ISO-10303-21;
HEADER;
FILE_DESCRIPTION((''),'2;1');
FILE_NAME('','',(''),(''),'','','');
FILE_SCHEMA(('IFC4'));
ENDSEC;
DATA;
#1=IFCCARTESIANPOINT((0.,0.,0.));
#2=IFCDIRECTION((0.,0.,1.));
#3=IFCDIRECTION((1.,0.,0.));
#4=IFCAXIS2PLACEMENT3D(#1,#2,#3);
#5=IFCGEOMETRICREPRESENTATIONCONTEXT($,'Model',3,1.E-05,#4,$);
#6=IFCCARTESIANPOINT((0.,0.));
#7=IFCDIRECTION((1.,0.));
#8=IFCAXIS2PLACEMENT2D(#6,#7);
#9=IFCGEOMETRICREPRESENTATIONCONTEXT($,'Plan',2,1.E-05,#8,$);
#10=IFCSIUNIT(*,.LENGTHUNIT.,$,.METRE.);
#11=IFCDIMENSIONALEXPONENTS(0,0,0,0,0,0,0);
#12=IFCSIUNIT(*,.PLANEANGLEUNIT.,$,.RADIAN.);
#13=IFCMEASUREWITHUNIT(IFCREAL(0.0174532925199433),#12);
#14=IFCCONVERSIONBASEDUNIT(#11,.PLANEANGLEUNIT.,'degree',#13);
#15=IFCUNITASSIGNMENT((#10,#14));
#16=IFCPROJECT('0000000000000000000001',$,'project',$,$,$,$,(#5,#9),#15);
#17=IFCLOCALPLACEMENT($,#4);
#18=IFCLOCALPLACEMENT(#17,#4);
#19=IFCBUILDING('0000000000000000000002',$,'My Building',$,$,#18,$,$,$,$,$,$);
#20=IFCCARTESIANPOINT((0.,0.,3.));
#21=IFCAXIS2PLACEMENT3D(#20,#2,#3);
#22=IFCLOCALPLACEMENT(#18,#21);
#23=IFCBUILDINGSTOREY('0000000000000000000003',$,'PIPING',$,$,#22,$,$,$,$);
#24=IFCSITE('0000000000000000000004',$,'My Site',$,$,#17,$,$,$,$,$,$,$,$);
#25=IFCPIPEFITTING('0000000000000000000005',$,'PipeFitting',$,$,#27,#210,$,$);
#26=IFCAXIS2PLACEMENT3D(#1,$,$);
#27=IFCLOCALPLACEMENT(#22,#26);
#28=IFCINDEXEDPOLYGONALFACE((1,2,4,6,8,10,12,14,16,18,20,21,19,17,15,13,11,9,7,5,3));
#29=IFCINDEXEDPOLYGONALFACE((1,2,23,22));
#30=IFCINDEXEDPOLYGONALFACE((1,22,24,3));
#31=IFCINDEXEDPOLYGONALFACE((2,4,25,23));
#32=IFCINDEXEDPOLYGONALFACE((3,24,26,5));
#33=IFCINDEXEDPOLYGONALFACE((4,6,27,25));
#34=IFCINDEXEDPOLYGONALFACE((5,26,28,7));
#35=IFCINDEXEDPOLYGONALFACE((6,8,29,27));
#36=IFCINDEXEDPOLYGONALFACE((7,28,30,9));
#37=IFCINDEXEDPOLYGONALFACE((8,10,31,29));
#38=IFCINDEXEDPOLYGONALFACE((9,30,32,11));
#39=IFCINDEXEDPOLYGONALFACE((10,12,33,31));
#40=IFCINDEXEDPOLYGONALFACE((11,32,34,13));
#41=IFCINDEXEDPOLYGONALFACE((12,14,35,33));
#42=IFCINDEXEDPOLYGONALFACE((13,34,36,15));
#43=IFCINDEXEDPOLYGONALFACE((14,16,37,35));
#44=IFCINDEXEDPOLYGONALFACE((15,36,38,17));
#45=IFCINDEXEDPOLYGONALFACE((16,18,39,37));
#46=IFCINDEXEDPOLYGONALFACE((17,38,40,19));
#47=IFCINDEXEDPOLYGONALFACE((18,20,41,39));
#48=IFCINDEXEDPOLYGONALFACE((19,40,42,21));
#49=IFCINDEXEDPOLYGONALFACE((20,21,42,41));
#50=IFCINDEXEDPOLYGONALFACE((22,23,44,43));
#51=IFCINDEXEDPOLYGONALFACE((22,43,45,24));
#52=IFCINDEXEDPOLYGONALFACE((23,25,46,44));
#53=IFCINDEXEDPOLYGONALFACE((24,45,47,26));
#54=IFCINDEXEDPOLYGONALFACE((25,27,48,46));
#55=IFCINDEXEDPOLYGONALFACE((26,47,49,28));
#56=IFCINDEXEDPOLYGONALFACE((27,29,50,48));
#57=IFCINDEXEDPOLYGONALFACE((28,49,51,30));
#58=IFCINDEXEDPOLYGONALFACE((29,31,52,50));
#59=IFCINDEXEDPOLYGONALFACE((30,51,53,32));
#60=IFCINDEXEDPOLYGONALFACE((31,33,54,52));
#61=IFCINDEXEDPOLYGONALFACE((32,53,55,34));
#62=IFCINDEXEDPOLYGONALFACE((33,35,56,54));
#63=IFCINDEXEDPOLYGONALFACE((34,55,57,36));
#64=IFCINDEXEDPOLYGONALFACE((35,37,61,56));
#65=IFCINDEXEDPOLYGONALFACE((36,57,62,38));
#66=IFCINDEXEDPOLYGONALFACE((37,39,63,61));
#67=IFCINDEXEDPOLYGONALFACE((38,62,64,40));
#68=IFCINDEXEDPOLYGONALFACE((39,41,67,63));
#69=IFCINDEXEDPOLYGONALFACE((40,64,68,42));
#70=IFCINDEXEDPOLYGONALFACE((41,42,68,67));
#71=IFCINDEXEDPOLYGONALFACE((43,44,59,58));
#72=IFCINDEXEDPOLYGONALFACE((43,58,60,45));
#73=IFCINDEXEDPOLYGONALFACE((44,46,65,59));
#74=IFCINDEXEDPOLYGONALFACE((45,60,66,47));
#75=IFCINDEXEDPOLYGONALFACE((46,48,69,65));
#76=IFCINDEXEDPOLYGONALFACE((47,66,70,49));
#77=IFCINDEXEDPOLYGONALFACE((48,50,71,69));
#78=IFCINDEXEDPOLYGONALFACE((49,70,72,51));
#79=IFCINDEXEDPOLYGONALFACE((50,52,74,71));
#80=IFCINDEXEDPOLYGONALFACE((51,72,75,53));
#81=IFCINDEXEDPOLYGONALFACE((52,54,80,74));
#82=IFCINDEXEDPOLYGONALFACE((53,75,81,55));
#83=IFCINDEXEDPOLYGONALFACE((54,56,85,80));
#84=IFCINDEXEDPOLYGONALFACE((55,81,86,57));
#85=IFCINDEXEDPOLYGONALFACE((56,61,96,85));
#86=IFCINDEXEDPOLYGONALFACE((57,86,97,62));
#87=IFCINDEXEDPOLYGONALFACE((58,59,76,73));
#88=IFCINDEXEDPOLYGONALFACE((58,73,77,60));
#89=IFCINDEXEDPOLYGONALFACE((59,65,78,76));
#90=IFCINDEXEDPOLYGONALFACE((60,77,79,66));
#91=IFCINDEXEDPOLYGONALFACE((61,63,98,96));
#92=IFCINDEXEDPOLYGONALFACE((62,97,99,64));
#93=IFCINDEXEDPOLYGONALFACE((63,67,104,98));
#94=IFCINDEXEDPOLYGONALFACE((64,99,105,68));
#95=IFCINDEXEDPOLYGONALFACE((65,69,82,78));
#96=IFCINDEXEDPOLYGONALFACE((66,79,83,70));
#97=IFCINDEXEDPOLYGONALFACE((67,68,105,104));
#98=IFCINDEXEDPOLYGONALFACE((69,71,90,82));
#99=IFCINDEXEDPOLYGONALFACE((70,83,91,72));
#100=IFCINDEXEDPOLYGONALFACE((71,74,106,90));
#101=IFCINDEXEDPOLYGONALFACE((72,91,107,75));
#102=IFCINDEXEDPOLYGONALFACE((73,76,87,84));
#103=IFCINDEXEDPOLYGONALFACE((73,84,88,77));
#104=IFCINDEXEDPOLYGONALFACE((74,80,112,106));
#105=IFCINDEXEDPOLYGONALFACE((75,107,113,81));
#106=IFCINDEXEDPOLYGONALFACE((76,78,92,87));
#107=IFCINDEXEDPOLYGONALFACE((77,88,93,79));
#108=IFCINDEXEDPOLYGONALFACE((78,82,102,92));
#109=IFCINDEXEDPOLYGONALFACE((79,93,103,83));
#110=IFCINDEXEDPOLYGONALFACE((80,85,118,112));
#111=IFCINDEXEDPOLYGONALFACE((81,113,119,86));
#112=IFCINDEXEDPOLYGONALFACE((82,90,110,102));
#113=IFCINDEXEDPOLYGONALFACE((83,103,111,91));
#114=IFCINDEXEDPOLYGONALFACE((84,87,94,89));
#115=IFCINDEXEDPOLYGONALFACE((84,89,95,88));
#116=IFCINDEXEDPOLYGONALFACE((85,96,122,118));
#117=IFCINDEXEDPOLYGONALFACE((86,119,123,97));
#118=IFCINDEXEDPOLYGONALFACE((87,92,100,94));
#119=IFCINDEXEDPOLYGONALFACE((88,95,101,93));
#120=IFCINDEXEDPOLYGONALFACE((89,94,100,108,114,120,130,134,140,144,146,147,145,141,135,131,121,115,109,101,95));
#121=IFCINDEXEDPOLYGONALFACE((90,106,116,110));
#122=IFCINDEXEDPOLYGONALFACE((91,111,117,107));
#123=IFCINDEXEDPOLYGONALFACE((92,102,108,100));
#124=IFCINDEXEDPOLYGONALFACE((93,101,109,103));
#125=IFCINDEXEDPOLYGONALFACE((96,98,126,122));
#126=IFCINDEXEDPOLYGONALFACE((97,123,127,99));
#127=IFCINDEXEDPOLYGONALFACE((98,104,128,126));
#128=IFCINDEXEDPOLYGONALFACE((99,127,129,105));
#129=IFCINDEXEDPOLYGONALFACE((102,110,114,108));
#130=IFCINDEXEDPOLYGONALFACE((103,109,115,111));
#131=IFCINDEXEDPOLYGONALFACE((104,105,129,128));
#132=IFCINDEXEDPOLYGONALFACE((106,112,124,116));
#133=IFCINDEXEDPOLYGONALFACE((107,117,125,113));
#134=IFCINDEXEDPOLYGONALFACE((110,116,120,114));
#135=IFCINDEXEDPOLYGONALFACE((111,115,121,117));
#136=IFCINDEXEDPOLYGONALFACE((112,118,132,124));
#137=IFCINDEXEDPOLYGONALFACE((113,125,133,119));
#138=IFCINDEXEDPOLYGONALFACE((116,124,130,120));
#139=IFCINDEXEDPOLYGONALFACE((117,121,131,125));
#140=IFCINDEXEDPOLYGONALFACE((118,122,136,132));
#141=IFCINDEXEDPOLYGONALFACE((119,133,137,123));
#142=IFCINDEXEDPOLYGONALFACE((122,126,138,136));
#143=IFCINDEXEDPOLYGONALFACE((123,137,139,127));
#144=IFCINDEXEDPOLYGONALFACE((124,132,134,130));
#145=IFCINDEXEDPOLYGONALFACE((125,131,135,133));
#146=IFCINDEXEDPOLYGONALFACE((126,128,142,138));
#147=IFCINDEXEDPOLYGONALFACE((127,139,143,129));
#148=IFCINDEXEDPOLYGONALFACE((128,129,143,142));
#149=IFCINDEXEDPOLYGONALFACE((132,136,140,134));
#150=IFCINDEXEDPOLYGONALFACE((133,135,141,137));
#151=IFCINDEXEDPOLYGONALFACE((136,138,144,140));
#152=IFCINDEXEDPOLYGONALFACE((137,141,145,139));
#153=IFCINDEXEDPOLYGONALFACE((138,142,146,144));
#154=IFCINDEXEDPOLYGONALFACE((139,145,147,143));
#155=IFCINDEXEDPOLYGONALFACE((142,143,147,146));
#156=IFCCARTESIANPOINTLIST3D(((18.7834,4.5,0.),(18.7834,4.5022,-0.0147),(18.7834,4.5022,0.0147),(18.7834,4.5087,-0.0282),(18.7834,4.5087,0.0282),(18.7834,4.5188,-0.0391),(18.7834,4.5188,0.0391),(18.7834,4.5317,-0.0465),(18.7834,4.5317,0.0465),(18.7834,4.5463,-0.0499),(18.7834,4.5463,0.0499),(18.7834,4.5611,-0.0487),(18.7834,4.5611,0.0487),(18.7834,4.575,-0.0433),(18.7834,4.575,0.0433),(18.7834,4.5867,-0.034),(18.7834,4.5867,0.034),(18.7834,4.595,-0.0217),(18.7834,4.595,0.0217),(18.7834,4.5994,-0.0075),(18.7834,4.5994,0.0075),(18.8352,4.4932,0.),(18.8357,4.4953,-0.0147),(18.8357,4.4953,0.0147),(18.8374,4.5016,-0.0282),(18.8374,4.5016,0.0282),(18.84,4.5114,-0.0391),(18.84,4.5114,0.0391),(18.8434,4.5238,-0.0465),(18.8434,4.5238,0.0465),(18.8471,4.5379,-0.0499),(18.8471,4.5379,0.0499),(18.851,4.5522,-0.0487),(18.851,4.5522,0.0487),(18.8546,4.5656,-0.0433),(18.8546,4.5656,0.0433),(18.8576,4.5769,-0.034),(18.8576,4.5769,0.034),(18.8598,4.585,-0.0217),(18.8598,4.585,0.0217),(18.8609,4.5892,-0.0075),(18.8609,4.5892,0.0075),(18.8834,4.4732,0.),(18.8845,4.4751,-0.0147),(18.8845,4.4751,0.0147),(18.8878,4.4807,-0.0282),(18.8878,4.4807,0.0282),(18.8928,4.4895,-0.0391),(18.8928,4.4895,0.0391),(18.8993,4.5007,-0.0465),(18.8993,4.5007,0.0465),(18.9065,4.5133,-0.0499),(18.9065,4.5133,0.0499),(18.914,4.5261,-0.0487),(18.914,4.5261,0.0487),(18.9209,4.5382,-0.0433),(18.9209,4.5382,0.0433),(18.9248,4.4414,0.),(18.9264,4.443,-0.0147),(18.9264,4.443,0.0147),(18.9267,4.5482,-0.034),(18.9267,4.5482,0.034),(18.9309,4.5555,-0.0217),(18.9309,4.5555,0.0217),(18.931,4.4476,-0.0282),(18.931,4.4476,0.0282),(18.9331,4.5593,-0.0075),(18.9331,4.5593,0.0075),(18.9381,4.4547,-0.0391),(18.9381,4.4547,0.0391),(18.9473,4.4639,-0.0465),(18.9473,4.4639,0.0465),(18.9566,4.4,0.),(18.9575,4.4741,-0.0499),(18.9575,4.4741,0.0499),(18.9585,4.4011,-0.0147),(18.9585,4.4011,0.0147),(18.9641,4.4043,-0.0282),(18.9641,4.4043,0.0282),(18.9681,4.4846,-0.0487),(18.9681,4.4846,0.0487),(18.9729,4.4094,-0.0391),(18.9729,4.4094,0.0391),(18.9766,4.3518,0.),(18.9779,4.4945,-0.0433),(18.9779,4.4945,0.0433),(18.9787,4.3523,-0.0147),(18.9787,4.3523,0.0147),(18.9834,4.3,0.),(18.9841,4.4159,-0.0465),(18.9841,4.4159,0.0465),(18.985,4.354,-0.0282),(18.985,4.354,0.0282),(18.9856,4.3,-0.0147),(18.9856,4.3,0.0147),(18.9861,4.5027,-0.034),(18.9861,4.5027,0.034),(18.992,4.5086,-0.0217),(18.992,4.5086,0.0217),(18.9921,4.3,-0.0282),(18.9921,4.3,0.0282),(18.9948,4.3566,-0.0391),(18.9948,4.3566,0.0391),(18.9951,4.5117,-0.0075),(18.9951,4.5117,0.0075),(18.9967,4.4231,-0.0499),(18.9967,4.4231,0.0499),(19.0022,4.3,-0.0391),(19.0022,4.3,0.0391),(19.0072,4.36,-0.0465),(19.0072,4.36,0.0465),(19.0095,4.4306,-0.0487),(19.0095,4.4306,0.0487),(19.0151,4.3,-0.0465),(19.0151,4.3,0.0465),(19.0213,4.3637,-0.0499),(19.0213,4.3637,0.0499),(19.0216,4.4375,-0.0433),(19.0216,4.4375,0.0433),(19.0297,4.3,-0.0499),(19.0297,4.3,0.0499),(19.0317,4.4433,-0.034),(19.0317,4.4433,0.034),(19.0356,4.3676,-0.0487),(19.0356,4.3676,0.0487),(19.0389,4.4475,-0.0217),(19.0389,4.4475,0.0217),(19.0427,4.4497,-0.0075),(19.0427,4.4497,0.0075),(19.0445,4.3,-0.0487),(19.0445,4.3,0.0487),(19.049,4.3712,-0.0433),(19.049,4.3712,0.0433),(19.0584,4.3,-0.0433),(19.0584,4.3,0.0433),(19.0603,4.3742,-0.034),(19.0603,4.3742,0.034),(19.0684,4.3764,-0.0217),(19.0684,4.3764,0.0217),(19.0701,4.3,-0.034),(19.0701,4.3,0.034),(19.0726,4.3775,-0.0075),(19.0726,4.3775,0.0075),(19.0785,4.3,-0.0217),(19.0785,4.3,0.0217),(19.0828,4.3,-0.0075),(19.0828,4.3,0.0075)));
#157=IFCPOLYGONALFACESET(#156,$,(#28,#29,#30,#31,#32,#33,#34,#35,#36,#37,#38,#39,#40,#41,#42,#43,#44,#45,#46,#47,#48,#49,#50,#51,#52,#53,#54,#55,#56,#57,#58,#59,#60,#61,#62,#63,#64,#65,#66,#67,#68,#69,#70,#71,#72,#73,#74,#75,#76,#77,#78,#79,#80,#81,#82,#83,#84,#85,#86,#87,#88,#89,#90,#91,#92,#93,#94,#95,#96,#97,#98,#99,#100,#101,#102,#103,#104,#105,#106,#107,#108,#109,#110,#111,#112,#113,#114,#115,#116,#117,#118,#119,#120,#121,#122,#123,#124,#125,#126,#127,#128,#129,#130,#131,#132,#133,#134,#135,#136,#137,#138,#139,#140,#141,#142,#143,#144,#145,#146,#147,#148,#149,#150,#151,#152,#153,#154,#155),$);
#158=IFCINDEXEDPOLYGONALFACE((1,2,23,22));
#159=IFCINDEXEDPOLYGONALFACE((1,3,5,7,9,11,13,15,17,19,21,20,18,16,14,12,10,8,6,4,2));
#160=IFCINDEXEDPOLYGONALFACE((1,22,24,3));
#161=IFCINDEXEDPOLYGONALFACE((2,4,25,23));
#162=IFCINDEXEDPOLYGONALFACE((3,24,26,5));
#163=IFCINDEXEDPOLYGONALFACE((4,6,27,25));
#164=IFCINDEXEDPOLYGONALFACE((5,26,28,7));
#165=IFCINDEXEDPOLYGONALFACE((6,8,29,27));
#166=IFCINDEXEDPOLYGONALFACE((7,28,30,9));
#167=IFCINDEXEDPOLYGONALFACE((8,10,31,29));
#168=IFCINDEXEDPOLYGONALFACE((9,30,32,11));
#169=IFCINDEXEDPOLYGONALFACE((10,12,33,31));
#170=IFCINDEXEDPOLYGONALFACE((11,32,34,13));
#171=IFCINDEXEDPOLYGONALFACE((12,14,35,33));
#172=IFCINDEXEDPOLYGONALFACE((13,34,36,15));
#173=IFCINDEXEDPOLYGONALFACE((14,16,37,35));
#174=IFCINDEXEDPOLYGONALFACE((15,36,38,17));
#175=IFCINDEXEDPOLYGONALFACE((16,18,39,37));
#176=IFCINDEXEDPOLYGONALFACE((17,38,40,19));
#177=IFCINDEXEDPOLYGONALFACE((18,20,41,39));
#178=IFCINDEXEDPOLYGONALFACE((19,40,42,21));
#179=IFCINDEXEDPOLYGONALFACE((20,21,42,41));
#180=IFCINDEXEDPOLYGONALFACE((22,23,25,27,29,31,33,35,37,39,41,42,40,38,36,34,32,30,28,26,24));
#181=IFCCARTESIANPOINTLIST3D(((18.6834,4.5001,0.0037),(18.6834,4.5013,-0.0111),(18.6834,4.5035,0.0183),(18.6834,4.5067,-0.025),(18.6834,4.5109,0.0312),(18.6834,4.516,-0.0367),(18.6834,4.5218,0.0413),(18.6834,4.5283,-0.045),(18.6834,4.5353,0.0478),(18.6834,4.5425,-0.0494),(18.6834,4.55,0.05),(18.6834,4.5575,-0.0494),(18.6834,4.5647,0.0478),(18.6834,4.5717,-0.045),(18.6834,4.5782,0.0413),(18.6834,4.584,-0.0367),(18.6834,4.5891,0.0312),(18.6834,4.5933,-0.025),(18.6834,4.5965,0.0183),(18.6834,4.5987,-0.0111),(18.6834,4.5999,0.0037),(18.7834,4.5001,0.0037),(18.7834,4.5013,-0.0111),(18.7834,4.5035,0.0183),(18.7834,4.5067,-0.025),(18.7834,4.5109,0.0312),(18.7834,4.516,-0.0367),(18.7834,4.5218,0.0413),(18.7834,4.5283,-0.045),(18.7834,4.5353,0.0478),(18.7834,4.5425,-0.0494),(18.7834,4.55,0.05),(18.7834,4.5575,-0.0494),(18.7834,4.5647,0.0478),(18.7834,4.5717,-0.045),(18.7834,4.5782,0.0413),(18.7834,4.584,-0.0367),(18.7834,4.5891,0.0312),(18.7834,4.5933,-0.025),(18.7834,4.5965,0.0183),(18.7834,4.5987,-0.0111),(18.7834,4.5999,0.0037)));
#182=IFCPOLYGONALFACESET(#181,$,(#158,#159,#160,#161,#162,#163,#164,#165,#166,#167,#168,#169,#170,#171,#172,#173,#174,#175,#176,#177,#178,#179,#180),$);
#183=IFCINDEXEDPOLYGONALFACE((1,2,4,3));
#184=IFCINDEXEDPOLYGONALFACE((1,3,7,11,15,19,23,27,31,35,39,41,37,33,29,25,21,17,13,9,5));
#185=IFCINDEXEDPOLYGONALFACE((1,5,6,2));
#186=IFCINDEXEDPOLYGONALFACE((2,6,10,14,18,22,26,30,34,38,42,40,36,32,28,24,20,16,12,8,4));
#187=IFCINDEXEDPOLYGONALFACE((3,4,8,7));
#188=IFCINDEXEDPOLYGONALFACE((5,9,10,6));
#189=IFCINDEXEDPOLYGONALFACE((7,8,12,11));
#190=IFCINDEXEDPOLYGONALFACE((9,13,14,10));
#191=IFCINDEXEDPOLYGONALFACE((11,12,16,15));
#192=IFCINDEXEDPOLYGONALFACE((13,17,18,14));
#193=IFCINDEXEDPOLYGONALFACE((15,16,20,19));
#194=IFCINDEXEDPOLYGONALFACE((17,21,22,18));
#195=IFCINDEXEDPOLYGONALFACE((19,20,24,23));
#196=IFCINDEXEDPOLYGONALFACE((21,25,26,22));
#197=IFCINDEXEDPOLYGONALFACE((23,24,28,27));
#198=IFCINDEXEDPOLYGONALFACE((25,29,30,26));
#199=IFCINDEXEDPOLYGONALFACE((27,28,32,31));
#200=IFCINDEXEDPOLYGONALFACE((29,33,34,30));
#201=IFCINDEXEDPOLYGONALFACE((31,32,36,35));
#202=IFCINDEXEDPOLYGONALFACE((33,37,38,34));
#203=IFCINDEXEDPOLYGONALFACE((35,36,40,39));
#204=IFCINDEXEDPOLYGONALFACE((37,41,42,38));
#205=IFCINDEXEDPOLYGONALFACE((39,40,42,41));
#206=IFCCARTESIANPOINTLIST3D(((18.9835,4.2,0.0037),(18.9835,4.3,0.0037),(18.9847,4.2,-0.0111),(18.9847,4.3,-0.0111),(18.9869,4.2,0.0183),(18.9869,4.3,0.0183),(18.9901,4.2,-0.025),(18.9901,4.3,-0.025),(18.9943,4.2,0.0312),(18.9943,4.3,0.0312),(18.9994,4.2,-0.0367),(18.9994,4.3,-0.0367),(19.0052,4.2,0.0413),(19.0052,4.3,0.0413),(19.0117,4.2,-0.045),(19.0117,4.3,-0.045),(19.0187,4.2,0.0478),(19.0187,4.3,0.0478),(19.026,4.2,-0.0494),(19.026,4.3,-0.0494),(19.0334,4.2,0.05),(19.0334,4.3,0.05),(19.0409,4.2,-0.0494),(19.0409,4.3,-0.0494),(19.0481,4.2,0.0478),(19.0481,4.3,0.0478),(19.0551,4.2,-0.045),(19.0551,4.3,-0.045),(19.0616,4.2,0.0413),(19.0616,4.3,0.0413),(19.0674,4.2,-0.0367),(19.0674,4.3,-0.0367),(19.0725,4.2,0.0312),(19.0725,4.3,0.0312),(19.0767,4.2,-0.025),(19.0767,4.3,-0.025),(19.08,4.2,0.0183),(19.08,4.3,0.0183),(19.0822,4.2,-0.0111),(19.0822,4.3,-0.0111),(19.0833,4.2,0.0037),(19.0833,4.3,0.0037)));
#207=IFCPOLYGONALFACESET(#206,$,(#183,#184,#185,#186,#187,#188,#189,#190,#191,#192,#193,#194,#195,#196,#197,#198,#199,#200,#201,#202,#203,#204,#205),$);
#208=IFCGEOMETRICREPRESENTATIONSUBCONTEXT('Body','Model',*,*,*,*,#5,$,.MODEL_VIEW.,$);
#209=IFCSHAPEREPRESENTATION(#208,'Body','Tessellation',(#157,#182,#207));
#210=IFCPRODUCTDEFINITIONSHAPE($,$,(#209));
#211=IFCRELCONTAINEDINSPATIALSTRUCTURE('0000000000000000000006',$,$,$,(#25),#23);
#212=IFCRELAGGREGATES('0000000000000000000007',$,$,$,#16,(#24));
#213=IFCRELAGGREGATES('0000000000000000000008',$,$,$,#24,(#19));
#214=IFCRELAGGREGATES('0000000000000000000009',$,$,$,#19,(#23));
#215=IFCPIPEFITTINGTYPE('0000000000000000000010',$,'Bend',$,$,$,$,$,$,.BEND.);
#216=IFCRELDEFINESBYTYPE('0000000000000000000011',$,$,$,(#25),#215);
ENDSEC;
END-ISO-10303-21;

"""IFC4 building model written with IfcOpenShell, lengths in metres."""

from ifc_helpers import new_model, entity, si_unit, converted_unit, frame, origin_with_axes, origin_2d_with_axis, place, context, subcontext, project, spatial, circle, extrude, source, transform, mapped, type_object, type_shapes, element, save


model = new_model("IFC4")

# Units and contexts
model_context = context("Model", 3, precision=1e-05, world=origin_with_axes())
plan_context = context("Plan", 2, precision=1e-05, world=origin_2d_with_axis())
body_context = subcontext(model_context, "Body", "Model", "MODEL_VIEW")
ifc_project = project(units=[si_unit("LENGTHUNIT", "METRE"), converted_unit("PLANEANGLEUNIT", "degree", entity("IfcReal", 0.0174532925199433), si_unit("PLANEANGLEUNIT", "RADIAN"), dimensions=[0, 0, 0, 0, 0, 0, 0])], contexts=[model_context, plan_context])

# Site, building, storey
site_placement = place(None, origin_with_axes())
site = spatial("IfcSite", under=ifc_project, at=site_placement, Name="My Site")
building_placement = place(site_placement, origin_with_axes())
building = spatial("IfcBuilding", under=site, at=building_placement, Name="My Building")
storey_placement = place(building_placement, frame((0.0, 0.0, 3.0), z_axis=(0.0, 0.0, 1.0), x_axis=(1.0, 0.0, 0.0)))
storey = spatial("IfcBuildingStorey", under=building, at=storey_placement, Name="PIPING")

# Pipe fitting
pipe_fitting_type = type_object("IfcPipeFittingType", Name="Bend", PredefinedType="BEND")
shared_shape = source(origin_with_axes(), body_context, "Body", "SolidModel", [
    entity("IfcSweptDiskSolid", entity("IfcIndexedPolyCurve", entity("IfcCartesianPointList3D", [[0.0, 0.0, -0.1], [0.0, -0.0732, -0.2768], [0.0, -0.25, -0.35]]), [entity("IfcArcIndex", [1, 2, 3])]), 0.05),
    extrude(circle(Radius=0.05), origin_with_axes(), (0.0, 0.0, -1.0), 0.1),
    extrude(circle(Radius=0.05), frame((0.0, -0.25, -0.35), z_axis=(0.0, -1.0, 0.0), x_axis=(1.0, 0.0, 0.0)), (0.0, 0.0, 1.0), 0.1),
])
type_shapes(pipe_fitting_type, [shared_shape])
for number, where, z_axis, x_axis, name in (
    (1, (18.6834, 4.55, 0.0), (-1.0, 0.0, 0.0), (0.0, 0.0, 1.0), "PipeFitting"),
):
    element("IfcPipeFitting", number, at=place(storey_placement, frame(where, z_axis=z_axis, x_axis=x_axis)), inside=storey, type_object=pipe_fitting_type, Name=name, context=body_context, shape_type="MappedRepresentation", body=[
        mapped(shared_shape, transform((0.0, 0.0, 0.0), x_axis=(1.0, 0.0, 0.0), y_axis=(0.0, 1.0, 0.0), z_axis=(0.0, 0.0, 1.0), scale=1.0)),
    ])

save(model, "model.ifc")
